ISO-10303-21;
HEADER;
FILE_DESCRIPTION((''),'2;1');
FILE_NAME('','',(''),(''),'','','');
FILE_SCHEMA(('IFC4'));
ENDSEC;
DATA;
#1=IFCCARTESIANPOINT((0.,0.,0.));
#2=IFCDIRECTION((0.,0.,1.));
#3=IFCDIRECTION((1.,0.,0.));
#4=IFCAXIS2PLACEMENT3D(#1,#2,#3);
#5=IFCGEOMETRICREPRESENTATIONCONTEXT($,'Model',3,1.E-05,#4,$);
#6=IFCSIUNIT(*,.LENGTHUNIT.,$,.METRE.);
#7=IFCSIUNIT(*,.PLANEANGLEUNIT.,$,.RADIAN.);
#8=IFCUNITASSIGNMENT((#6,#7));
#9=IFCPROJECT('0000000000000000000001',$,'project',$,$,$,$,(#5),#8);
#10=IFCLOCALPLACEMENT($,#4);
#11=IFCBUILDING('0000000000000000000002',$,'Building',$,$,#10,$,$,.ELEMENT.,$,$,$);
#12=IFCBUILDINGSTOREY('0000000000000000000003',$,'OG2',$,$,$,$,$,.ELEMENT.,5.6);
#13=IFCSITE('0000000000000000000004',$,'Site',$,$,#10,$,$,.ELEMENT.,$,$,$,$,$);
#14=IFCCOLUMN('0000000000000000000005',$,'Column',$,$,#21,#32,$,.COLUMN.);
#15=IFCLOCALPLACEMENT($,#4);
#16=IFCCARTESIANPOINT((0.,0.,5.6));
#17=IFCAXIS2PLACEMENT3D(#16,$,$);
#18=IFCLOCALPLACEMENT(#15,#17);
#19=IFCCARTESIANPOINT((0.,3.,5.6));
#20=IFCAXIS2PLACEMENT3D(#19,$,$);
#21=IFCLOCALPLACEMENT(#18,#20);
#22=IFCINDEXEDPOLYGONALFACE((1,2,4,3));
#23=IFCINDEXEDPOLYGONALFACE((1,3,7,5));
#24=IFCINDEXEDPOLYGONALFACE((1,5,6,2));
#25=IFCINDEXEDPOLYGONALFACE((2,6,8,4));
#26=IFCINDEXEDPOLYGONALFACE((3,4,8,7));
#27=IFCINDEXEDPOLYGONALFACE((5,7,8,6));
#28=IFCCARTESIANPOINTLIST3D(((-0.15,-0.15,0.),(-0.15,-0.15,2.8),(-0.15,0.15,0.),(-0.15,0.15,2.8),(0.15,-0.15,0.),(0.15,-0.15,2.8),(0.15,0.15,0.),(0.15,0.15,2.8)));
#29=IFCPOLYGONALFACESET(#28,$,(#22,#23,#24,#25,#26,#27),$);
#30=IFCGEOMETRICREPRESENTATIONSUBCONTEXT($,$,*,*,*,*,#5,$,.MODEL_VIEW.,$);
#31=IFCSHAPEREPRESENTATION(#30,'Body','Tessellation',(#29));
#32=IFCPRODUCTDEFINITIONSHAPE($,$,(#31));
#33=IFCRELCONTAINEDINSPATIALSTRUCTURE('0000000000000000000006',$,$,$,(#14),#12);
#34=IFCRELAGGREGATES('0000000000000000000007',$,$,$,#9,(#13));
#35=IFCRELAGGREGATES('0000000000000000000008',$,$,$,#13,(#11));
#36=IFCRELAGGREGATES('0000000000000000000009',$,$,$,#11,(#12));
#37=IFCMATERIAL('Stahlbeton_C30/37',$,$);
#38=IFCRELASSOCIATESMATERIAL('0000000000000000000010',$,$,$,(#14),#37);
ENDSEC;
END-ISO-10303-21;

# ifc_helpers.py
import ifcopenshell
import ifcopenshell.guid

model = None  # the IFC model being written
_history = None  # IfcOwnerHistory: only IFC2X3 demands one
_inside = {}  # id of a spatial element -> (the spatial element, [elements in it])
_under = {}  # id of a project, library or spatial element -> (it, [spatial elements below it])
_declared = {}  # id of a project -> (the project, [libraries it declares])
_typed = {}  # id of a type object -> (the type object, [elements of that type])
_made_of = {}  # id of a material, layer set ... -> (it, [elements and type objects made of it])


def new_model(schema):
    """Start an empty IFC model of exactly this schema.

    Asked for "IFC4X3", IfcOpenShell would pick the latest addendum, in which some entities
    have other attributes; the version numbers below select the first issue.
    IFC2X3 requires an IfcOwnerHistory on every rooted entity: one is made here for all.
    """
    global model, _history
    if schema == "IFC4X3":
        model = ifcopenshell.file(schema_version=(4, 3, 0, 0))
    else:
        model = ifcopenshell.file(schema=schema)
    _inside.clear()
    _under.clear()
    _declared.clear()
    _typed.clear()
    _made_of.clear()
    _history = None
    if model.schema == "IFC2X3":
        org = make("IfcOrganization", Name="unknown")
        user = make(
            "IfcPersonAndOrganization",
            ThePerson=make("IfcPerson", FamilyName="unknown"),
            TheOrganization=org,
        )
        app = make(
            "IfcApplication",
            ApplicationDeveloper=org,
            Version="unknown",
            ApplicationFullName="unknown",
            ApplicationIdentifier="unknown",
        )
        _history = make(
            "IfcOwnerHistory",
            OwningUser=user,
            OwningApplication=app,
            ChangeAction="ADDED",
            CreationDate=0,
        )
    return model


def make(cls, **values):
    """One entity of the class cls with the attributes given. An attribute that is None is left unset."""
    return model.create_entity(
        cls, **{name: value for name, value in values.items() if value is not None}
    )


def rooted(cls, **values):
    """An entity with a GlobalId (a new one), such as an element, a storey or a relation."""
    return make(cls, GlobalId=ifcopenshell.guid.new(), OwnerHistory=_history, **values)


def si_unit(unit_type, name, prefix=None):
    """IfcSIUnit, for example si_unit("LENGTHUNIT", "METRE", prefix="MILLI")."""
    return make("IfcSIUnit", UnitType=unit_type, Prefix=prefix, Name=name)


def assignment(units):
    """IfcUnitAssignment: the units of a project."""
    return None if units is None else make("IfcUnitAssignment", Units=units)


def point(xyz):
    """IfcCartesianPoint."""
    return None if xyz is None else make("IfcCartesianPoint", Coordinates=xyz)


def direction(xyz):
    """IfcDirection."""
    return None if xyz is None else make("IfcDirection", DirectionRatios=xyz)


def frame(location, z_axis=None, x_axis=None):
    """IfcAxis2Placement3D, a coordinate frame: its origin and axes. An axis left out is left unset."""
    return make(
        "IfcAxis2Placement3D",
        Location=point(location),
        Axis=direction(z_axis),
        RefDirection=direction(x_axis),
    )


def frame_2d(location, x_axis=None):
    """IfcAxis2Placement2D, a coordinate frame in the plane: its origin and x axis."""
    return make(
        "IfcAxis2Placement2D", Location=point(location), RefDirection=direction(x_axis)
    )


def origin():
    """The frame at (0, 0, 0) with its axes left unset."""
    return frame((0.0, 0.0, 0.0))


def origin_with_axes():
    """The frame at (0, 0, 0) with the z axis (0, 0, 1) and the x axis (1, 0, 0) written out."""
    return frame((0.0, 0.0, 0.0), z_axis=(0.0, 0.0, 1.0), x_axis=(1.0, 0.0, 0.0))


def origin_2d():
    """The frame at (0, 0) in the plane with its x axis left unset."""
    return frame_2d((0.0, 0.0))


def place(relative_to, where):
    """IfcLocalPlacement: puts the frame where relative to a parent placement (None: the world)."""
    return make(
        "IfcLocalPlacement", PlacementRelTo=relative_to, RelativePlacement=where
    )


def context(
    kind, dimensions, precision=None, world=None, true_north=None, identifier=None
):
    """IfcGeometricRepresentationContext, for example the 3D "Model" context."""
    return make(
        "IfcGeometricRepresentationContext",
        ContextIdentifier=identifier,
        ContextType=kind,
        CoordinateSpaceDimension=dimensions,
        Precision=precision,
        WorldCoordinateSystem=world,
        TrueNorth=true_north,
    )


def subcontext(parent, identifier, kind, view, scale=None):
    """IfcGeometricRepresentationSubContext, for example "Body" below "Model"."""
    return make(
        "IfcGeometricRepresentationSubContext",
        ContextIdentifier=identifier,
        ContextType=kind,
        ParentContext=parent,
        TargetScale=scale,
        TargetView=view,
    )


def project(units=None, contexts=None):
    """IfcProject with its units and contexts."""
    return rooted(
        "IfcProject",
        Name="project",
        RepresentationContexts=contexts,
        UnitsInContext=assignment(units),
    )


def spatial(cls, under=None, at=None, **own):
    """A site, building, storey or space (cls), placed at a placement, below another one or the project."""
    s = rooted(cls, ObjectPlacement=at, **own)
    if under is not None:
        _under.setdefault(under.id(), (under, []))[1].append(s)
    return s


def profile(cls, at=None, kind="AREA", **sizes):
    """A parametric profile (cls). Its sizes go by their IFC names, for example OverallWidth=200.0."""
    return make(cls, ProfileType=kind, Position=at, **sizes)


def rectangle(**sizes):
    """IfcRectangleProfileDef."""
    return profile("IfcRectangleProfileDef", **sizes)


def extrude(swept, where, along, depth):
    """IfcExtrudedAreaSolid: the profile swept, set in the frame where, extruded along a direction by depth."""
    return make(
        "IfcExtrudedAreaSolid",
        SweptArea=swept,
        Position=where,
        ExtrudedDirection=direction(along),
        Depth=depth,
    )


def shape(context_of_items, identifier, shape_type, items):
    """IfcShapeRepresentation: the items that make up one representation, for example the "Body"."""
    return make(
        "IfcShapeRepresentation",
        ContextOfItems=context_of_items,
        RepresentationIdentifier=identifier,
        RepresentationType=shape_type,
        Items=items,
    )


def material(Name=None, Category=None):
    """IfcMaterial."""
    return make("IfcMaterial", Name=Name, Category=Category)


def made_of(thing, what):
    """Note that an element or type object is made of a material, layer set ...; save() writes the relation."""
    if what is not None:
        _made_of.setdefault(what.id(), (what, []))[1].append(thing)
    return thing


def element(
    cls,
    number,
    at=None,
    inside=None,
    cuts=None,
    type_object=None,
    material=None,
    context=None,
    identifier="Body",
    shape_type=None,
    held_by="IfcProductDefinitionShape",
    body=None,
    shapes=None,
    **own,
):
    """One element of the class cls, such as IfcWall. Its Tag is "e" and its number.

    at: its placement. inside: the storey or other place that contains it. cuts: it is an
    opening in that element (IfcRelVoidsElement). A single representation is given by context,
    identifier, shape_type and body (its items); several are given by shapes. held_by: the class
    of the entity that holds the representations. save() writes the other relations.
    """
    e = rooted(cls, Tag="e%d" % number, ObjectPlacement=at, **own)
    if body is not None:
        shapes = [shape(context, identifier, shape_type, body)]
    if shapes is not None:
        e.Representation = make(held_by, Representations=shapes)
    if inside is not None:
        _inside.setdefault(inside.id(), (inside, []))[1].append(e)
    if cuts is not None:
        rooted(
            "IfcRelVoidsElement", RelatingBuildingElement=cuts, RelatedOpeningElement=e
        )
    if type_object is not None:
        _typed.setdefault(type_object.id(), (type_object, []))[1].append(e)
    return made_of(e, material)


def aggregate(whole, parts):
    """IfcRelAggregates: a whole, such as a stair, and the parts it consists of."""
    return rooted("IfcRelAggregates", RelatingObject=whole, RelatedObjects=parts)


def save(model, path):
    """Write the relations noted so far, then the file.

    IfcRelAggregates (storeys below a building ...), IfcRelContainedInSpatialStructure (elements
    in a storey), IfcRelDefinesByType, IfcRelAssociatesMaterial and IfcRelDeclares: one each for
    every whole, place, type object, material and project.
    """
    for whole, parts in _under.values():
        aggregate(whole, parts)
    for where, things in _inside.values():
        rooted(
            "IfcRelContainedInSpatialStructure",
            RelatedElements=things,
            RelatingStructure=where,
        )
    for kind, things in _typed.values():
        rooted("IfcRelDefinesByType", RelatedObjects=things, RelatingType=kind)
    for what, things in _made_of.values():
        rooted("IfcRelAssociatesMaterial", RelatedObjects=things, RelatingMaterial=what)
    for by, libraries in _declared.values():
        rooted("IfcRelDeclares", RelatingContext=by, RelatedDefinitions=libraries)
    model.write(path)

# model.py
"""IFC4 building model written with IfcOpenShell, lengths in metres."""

from ifc_helpers import new_model, si_unit, frame, origin, origin_with_axes, origin_2d, place, context, subcontext, project, spatial, rectangle, extrude, material, element, save


model = new_model("IFC4")

# Units and contexts
model_context = context("Model", 3, precision=1e-05, world=origin_with_axes())
sub_context = subcontext(model_context, None, None, "MODEL_VIEW")
ifc_project = project(units=[si_unit("LENGTHUNIT", "METRE"), si_unit("PLANEANGLEUNIT", "RADIAN")], contexts=[model_context])

# Site, building, storey
placement_1 = place(None, origin_with_axes())
site = spatial("IfcSite", under=ifc_project, at=placement_1, Name="Site", CompositionType="ELEMENT")
building = spatial("IfcBuilding", under=site, at=placement_1, Name="Building", CompositionType="ELEMENT")
storey = spatial("IfcBuildingStorey", under=building, Name="OG2", CompositionType="ELEMENT", Elevation=5.6)

# Column
ifc_material = material(Name="Stahlbeton_C30/37")
placement_2 = place(None, origin_with_axes())
placement_3 = place(placement_2, frame((0.0, 0.0, 5.6)))
column_placement = place(placement_3, frame((0.0, 3.0, 5.6)))
element("IfcColumn", 1, at=column_placement, inside=storey, material=ifc_material, Name="Column", PredefinedType="COLUMN", context=sub_context, shape_type="SweptSolid", body=[
    extrude(rectangle(XDim=0.3, YDim=0.3, at=origin_2d()), origin(), (0.0, 0.0, 1.0), 2.8),
])

save(model, "model.ifc")
